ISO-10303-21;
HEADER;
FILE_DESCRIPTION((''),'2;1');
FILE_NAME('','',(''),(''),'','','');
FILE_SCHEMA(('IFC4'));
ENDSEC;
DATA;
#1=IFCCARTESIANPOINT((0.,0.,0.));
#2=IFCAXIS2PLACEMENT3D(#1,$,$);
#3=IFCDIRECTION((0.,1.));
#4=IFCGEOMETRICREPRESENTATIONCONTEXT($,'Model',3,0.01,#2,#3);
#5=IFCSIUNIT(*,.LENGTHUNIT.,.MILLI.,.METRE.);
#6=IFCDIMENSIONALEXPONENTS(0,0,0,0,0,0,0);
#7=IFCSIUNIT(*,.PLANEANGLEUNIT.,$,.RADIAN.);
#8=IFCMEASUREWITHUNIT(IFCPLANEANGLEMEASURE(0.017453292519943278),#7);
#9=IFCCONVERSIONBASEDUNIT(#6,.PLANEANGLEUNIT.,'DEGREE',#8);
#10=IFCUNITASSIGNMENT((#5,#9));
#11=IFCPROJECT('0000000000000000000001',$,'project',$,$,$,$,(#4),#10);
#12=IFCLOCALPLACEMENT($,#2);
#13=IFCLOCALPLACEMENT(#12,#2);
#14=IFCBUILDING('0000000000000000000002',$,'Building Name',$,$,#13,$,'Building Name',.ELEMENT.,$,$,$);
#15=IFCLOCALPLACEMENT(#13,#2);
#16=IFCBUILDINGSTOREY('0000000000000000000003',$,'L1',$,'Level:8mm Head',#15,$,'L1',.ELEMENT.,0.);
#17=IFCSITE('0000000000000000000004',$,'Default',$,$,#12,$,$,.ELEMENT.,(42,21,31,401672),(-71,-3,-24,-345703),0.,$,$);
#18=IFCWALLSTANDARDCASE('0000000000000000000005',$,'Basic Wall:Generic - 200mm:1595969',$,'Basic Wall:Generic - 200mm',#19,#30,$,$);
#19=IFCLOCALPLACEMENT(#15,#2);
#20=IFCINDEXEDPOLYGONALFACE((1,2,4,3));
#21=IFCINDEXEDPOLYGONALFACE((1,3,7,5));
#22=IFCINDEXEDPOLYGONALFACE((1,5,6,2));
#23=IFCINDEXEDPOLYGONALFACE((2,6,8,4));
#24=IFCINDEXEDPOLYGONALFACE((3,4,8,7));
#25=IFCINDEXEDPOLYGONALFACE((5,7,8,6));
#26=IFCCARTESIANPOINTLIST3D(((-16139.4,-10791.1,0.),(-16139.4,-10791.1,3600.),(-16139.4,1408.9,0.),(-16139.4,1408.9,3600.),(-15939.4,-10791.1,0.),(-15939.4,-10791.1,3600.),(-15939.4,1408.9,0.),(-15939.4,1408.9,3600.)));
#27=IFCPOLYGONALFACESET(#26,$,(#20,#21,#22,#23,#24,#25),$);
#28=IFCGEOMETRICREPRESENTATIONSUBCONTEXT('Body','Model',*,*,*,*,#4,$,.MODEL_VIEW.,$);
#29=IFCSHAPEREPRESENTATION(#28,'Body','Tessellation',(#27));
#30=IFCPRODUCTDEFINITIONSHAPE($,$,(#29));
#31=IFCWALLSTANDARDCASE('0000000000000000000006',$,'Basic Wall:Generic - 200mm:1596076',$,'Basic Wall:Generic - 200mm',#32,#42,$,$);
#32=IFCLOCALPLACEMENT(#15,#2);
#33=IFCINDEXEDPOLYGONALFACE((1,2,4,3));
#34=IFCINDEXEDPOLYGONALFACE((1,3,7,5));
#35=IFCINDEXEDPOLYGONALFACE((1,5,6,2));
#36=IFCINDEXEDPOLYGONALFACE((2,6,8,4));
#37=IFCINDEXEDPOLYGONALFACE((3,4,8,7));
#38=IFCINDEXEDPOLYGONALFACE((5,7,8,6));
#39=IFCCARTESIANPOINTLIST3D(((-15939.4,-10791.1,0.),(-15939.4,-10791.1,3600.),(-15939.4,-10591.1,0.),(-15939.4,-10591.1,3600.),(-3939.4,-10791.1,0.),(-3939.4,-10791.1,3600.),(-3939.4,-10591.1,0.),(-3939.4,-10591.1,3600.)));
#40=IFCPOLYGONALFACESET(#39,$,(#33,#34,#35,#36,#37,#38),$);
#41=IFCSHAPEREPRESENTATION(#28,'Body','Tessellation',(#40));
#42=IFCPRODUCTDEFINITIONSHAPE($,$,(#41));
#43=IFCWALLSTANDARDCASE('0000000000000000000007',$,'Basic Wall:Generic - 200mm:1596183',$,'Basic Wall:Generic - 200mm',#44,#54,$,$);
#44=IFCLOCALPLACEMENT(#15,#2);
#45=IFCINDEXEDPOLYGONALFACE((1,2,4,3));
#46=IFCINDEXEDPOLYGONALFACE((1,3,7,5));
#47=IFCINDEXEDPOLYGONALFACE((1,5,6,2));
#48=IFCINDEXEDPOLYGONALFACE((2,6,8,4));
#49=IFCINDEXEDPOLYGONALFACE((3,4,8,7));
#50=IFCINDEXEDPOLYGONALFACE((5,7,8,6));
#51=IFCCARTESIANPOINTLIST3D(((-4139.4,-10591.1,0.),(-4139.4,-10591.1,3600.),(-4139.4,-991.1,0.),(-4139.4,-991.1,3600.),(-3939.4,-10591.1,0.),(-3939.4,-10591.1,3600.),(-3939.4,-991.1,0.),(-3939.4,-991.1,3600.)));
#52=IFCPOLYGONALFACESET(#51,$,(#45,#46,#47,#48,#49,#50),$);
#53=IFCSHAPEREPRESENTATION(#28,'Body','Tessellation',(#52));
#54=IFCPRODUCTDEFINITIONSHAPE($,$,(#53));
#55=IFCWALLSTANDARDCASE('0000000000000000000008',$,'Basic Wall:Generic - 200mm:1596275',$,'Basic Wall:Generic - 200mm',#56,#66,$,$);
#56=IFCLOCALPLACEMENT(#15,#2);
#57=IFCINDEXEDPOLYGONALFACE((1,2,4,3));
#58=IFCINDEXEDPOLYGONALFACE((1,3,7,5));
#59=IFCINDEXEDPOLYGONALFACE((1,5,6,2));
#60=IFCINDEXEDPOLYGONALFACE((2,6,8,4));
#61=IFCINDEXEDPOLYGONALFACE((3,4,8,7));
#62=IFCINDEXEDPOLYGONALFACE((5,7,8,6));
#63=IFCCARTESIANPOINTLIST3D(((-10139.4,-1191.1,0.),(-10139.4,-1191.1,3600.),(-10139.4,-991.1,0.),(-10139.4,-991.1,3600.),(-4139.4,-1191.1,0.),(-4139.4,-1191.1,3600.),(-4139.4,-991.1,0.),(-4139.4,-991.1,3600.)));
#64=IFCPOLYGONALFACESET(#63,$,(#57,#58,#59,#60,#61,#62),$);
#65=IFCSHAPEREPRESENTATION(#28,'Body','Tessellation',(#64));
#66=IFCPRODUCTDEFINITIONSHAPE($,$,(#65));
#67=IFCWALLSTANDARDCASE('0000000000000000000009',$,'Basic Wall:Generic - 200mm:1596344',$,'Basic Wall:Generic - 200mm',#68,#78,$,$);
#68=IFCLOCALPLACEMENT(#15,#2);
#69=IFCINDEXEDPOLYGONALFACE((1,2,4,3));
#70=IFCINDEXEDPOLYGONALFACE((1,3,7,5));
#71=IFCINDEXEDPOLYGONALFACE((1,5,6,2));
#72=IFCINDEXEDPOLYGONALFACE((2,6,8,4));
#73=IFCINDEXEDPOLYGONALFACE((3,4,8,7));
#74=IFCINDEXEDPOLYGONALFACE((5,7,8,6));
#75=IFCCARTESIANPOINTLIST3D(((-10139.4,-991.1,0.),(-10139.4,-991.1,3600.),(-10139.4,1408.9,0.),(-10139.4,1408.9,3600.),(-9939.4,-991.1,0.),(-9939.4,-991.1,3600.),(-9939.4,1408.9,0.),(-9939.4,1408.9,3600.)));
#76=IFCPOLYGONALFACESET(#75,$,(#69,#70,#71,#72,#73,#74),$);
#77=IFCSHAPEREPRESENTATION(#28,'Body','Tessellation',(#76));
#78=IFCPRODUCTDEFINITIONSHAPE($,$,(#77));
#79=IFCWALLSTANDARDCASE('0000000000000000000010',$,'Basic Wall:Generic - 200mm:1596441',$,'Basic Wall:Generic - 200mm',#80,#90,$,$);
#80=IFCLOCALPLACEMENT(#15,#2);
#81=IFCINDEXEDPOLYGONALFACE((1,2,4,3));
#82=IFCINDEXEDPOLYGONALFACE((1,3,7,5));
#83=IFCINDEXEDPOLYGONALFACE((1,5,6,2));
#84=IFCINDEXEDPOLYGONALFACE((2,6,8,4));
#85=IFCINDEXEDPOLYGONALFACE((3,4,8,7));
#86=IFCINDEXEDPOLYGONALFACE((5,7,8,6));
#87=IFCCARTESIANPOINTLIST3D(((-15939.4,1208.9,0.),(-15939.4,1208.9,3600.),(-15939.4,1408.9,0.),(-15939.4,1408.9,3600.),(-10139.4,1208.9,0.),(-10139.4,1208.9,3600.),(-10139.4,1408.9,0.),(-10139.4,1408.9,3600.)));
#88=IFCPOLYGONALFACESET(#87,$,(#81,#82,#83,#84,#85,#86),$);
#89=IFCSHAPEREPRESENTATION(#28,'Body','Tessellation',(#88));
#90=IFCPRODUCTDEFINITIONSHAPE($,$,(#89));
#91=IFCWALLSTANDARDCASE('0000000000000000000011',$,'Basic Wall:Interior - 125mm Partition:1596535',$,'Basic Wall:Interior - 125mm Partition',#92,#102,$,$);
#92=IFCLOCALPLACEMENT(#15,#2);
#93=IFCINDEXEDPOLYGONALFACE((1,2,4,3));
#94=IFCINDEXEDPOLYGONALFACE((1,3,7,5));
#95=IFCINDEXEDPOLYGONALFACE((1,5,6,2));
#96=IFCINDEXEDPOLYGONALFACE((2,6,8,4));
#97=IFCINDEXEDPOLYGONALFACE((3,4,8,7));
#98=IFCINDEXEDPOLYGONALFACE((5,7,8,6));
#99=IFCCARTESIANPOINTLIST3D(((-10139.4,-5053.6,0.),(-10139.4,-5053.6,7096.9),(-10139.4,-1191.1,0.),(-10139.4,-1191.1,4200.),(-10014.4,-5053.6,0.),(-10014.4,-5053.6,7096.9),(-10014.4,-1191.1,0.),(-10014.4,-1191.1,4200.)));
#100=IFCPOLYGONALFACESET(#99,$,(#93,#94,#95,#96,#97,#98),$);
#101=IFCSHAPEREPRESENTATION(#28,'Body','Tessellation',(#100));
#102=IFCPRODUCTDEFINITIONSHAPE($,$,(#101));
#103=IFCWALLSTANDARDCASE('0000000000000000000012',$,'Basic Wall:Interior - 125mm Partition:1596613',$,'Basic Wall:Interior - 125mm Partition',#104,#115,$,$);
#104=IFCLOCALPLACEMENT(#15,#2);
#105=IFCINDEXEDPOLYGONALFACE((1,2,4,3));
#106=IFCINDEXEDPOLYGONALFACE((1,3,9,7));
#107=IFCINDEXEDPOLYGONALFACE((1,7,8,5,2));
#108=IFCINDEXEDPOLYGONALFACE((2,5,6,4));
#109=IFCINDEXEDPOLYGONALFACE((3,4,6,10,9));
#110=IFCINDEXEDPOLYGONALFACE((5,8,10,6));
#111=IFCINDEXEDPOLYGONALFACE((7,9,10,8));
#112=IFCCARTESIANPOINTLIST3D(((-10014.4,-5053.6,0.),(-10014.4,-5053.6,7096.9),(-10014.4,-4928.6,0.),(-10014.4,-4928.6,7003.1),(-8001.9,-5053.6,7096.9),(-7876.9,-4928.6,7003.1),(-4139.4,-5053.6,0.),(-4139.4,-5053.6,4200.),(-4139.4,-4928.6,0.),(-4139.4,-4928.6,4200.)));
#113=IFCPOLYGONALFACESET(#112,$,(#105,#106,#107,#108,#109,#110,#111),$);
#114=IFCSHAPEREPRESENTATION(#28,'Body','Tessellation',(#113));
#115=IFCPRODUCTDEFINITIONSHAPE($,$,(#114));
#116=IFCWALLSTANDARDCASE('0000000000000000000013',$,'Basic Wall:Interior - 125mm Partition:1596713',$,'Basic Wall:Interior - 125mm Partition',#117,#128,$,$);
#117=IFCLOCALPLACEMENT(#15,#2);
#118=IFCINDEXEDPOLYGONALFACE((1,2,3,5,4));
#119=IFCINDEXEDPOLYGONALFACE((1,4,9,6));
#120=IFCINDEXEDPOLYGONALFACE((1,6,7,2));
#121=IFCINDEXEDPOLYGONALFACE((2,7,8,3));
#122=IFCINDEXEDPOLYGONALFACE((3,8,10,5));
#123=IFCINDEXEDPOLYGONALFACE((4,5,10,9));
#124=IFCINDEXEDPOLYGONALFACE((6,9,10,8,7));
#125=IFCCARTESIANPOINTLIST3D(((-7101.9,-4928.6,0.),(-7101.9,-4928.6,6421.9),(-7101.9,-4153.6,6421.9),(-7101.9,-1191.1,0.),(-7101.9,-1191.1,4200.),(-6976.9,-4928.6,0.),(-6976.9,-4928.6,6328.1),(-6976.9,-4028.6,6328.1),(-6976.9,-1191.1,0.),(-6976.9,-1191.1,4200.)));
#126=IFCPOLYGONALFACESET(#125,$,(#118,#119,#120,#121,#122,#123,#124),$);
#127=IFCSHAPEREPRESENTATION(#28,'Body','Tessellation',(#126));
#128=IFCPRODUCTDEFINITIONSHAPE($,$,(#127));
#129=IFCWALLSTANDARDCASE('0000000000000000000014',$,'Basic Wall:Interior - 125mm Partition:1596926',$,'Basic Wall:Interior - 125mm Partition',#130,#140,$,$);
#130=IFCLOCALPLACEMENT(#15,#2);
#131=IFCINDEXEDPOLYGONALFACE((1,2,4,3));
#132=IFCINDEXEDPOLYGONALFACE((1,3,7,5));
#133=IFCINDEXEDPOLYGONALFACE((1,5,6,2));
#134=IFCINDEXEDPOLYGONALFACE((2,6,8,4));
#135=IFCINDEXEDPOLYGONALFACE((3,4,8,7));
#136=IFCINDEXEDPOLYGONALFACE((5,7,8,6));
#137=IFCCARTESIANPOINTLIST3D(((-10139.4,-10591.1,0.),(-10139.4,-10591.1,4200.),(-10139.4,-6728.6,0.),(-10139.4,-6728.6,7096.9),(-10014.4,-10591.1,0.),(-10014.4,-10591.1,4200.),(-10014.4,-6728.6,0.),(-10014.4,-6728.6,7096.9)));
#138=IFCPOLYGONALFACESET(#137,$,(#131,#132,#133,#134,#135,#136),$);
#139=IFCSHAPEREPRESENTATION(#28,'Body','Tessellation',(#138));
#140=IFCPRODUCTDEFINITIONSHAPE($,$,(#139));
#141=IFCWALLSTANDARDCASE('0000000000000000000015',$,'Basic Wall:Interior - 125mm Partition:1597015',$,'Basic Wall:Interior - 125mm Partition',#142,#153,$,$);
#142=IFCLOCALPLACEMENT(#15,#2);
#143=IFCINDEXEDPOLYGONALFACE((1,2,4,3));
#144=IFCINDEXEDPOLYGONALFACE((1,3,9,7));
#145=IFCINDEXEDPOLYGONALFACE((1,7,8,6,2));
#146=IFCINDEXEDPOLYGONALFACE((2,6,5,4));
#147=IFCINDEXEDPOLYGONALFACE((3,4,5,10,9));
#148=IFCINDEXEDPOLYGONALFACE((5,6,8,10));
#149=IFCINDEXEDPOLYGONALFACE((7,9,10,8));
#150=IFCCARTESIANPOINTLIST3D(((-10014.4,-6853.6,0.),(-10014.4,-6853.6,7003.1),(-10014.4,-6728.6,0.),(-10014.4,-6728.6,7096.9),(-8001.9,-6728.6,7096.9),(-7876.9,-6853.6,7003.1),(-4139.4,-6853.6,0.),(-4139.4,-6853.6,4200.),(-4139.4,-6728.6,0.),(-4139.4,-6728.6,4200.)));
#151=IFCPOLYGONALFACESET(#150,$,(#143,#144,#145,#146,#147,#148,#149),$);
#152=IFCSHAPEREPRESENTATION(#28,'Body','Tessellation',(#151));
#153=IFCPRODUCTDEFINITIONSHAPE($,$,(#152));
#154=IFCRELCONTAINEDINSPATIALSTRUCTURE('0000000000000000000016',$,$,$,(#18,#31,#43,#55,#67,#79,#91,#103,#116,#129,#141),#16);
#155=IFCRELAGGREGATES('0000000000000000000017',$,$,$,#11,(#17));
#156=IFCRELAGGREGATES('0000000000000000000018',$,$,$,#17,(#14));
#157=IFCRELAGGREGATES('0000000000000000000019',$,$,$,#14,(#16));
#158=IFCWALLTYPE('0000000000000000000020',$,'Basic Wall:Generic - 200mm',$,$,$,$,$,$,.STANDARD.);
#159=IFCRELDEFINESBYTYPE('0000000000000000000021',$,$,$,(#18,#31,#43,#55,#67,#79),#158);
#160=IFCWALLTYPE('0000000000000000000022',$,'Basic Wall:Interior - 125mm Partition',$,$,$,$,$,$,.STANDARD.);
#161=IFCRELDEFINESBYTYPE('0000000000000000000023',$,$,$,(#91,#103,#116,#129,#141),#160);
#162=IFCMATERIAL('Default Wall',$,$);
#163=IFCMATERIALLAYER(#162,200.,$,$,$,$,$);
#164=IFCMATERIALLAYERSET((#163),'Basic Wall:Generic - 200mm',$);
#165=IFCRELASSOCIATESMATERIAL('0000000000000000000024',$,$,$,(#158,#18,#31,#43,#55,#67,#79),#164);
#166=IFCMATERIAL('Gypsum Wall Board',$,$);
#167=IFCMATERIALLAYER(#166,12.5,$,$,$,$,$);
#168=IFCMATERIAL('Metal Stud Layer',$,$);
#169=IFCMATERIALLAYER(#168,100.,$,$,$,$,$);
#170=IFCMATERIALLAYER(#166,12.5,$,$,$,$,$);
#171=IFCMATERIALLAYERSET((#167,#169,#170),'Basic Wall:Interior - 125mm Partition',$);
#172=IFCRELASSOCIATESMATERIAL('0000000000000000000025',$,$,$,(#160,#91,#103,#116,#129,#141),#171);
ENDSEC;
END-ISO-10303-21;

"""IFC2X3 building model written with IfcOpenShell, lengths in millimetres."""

from ifc_helpers import new_model, entity, si_unit, converted_unit, direction, frame, frame_2d, origin, place, context, subcontext, project, spatial, polyline, rectangle, extrude, clip, bounded_halfspace, material, layer, layer_set, layer_usage, type_object, element, save


model = new_model("IFC2X3")

# Units and contexts
model_context = context("Model", 3, precision=0.01, world=origin(), true_north=direction((0.0, 1.0)))
body_context = subcontext(model_context, "Body", "Model", "MODEL_VIEW")
ifc_project = project(units=[si_unit("LENGTHUNIT", "METRE", prefix="MILLI"), converted_unit("PLANEANGLEUNIT", "DEGREE", entity("IfcPlaneAngleMeasure", 0.017453292519943278), si_unit("PLANEANGLEUNIT", "RADIAN"), dimensions=[0, 0, 0, 0, 0, 0, 0])], contexts=[model_context])

# Site, building, storey
site_placement = place(None, origin())
site = spatial("IfcSite", under=ifc_project, at=site_placement, Name="Default", CompositionType="ELEMENT", RefLatitude=(42, 21, 31, 401672), RefLongitude=(-71, -3, -24, -345703), RefElevation=0.0)
building_placement = place(site_placement, origin())
building = spatial("IfcBuilding", under=site, at=building_placement, Name="Building Name", LongName="Building Name", CompositionType="ELEMENT")
storey_placement = place(building_placement, origin())
storey = spatial("IfcBuildingStorey", under=building, at=storey_placement, Name="L1", ObjectType="Level:8mm Head", LongName="L1", CompositionType="ELEMENT", Elevation=0.0)

# Walls
ifc_material_1 = material(Name="Default Wall")
ifc_layer_1 = layer(ifc_material_1, 200.0)
ifc_layer_set_1 = layer_set([ifc_layer_1], Name="Basic Wall:Generic - 200mm")
ifc_layer_usage_1 = layer_usage(ifc_layer_set_1, "AXIS2", "NEGATIVE", 100.0)
wall_type_1 = type_object("IfcWallType", Name="Basic Wall:Generic - 200mm", PredefinedType="STANDARD", material=ifc_layer_set_1)
wall_1_placement = place(storey_placement, frame((-16039.4, 1408.9, 0.0), z_axis=(0.0, 0.0, 1.0), x_axis=(0.0, -1.0, 0.0)))
element("IfcWallStandardCase", 1, at=wall_1_placement, inside=storey, type_object=wall_type_1, material=ifc_layer_usage_1, Name="Basic Wall:Generic - 200mm:1595969", ObjectType="Basic Wall:Generic - 200mm", context=body_context, shape_type="SweptSolid", body=[
    extrude(rectangle(XDim=12200.0, YDim=200.0, at=frame_2d((6100.0, 0.0), x_axis=(-1.0, 0.0))), origin(), (0.0, 0.0, 1.0), 3600.0),
])
wall_2_placement = place(storey_placement, frame((-15939.4, -10691.1, 0.0)))
element("IfcWallStandardCase", 2, at=wall_2_placement, inside=storey, type_object=wall_type_1, material=ifc_layer_usage_1, Name="Basic Wall:Generic - 200mm:1596076", ObjectType="Basic Wall:Generic - 200mm", context=body_context, shape_type="SweptSolid", body=[
    extrude(rectangle(XDim=12000.0, YDim=200.0, at=frame_2d((6000.0, 0.0), x_axis=(-1.0, 0.0))), origin(), (0.0, 0.0, 1.0), 3600.0),
])
wall_3_placement = place(storey_placement, frame((-4039.4, -10591.1, 0.0), z_axis=(0.0, 0.0, 1.0), x_axis=(0.0, 1.0, 0.0)))
element("IfcWallStandardCase", 3, at=wall_3_placement, inside=storey, type_object=wall_type_1, material=ifc_layer_usage_1, Name="Basic Wall:Generic - 200mm:1596183", ObjectType="Basic Wall:Generic - 200mm", context=body_context, shape_type="SweptSolid", body=[
    extrude(rectangle(XDim=9600.0, YDim=200.0, at=frame_2d((4800.0, 0.0), x_axis=(-1.0, 0.0))), origin(), (0.0, 0.0, 1.0), 3600.0),
])
wall_4_placement = place(storey_placement, frame((-4139.4, -1091.1, 0.0), z_axis=(0.0, 0.0, 1.0), x_axis=(-1.0, 0.0, 0.0)))
element("IfcWallStandardCase", 4, at=wall_4_placement, inside=storey, type_object=wall_type_1, material=ifc_layer_usage_1, Name="Basic Wall:Generic - 200mm:1596275", ObjectType="Basic Wall:Generic - 200mm", context=body_context, shape_type="SweptSolid", body=[
    extrude(rectangle(XDim=6000.0, YDim=200.0, at=frame_2d((3000.0, 0.0), x_axis=(-1.0, 0.0))), origin(), (0.0, 0.0, 1.0), 3600.0),
])
wall_5_placement = place(storey_placement, frame((-10039.4, -991.1, 0.0), z_axis=(0.0, 0.0, 1.0), x_axis=(0.0, 1.0, 0.0)))
element("IfcWallStandardCase", 5, at=wall_5_placement, inside=storey, type_object=wall_type_1, material=ifc_layer_usage_1, Name="Basic Wall:Generic - 200mm:1596344", ObjectType="Basic Wall:Generic - 200mm", context=body_context, shape_type="SweptSolid", body=[
    extrude(rectangle(XDim=2400.0, YDim=200.0, at=frame_2d((1200.0, 0.0), x_axis=(-1.0, 0.0))), origin(), (0.0, 0.0, 1.0), 3600.0),
])
wall_6_placement = place(storey_placement, frame((-10139.4, 1308.9, 0.0), z_axis=(0.0, 0.0, 1.0), x_axis=(-1.0, 0.0, 0.0)))
element("IfcWallStandardCase", 6, at=wall_6_placement, inside=storey, type_object=wall_type_1, material=ifc_layer_usage_1, Name="Basic Wall:Generic - 200mm:1596441", ObjectType="Basic Wall:Generic - 200mm", context=body_context, shape_type="SweptSolid", body=[
    extrude(rectangle(XDim=5800.0, YDim=200.0, at=frame_2d((2900.0, 0.0), x_axis=(-1.0, 0.0))), origin(), (0.0, 0.0, 1.0), 3600.0),
])
ifc_material_2 = material(Name="Gypsum Wall Board")
ifc_layer_2 = layer(ifc_material_2, 12.5)
ifc_material_3 = material(Name="Metal Stud Layer")
ifc_layer_3 = layer(ifc_material_3, 100.0)
ifc_layer_4 = layer(ifc_material_2, 12.5)
ifc_layer_set_2 = layer_set([ifc_layer_2, ifc_layer_3, ifc_layer_4], Name="Basic Wall:Interior - 125mm Partition")
ifc_layer_usage_2 = layer_usage(ifc_layer_set_2, "AXIS2", "NEGATIVE", 62.5)
wall_type_2 = type_object("IfcWallType", Name="Basic Wall:Interior - 125mm Partition", PredefinedType="STANDARD", material=ifc_layer_set_2)
wall_7_placement = place(storey_placement, frame((-10076.9, -1191.1, 0.0), z_axis=(0.0, 0.0, 1.0), x_axis=(0.0, -1.0, 0.0)))
element("IfcWallStandardCase", 7, at=wall_7_placement, inside=storey, type_object=wall_type_2, material=ifc_layer_usage_2, Name="Basic Wall:Interior - 125mm Partition:1596535", ObjectType="Basic Wall:Interior - 125mm Partition", context=body_context, shape_type="Clipping", body=[
    clip(extrude(rectangle(XDim=3862.5, YDim=125.0, at=frame_2d((1931.3, 0.0), x_axis=(-1.0, 0.0))), origin(), (0.0, 0.0, 1.0), 7096.9), bounded_halfspace(frame((0.0, -62.5, 4200.0), z_axis=(-0.6, 0.0, 0.8), x_axis=(0.0, -1.0, 0.0)), False, frame((0.0, -62.5, 4200.0)), polyline([(0.0, 0.0), (3862.5, 0.0), (3862.5, 125.0), (3737.5, 125.0), (0.0, 125.0), (0.0, 0.0)]))),
])
wall_8_placement = place(storey_placement, frame((-10014.4, -4991.1, 0.0)))
element("IfcWallStandardCase", 8, at=wall_8_placement, inside=storey, type_object=wall_type_2, material=ifc_layer_usage_2, Name="Basic Wall:Interior - 125mm Partition:1596613", ObjectType="Basic Wall:Interior - 125mm Partition", context=body_context, shape_type="Clipping", body=[
    clip(clip(extrude(rectangle(XDim=5875.0, YDim=125.0, at=frame_2d((2937.5, 0.0), x_axis=(-1.0, 0.0))), origin(), (0.0, 0.0, 1.0), 7096.9), bounded_halfspace(frame((2012.5, -62.5, 7096.9), z_axis=(0.6, 0.0, 0.8), x_axis=(0.0, 1.0, 0.0)), False, frame((2012.5, -62.5, 7096.9)), polyline([(0.0, 0.0), (3862.5, 0.0), (3862.5, 125.0), (1025.0, 125.0), (900.0, 125.0), (125.0, 125.0), (0.0, 0.0)]))), bounded_halfspace(frame((0.0, -62.5, 7096.9), z_axis=(0.0, 0.6, 0.8), x_axis=(-1.0, 0.0, 0.0)), False, frame((0.0, -62.5, 7096.9)), polyline([(0.0, 0.0), (2012.5, 0.0), (2137.5, 125.0), (0.0, 125.0), (0.0, 0.0)]))),
])
wall_9_placement = place(storey_placement, frame((-7039.4, -4928.6, 0.0), z_axis=(0.0, 0.0, 1.0), x_axis=(0.0, 1.0, 0.0)))
element("IfcWallStandardCase", 9, at=wall_9_placement, inside=storey, type_object=wall_type_2, material=ifc_layer_usage_2, Name="Basic Wall:Interior - 125mm Partition:1596713", ObjectType="Basic Wall:Interior - 125mm Partition", context=body_context, shape_type="Clipping", body=[
    clip(clip(extrude(rectangle(XDim=3737.5, YDim=125.0, at=frame_2d((1868.8, 0.0), x_axis=(-1.0, 0.0))), origin(), (0.0, 0.0, 1.0), 6421.9), bounded_halfspace(frame((0.0, -62.5, 6328.1), z_axis=(0.0, -0.6, 0.8), x_axis=(1.0, 0.0, 0.0)), False, frame((0.0, -62.5, 6328.1)), polyline([(0.0, 0.0), (900.0, 0.0), (775.0, 125.0), (0.0, 125.0), (0.0, 0.0)]))), bounded_halfspace(frame((900.0, -62.5, 6328.1), z_axis=(0.6, 0.0, 0.8), x_axis=(0.0, 1.0, 0.0)), False, frame((900.0, -62.5, 6328.1)), polyline([(0.0, 0.0), (2837.5, 0.0), (2837.5, 125.0), (-125.0, 125.0), (0.0, 0.0)]))),
])
wall_10_placement = place(storey_placement, frame((-10076.9, -10591.1, 0.0), z_axis=(0.0, 0.0, 1.0), x_axis=(0.0, 1.0, 0.0)))
element("IfcWallStandardCase", 10, at=wall_10_placement, inside=storey, type_object=wall_type_2, material=ifc_layer_usage_2, Name="Basic Wall:Interior - 125mm Partition:1596926", ObjectType="Basic Wall:Interior - 125mm Partition", context=body_context, shape_type="Clipping", body=[
    clip(extrude(rectangle(XDim=3862.5, YDim=125.0, at=frame_2d((1931.3, 0.0), x_axis=(-1.0, 0.0))), origin(), (0.0, 0.0, 1.0), 7096.9), bounded_halfspace(frame((0.0, -62.5, 4200.0), z_axis=(-0.6, 0.0, 0.8), x_axis=(0.0, -1.0, 0.0)), False, frame((0.0, -62.5, 4200.0)), polyline([(0.0, 0.0), (3737.5, 0.0), (3862.5, 0.0), (3862.5, 125.0), (0.0, 125.0), (0.0, 0.0)]))),
])
wall_11_placement = place(storey_placement, frame((-10014.4, -6791.1, 0.0)))
element("IfcWallStandardCase", 11, at=wall_11_placement, inside=storey, type_object=wall_type_2, material=ifc_layer_usage_2, Name="Basic Wall:Interior - 125mm Partition:1597015", ObjectType="Basic Wall:Interior - 125mm Partition", context=body_context, shape_type="Clipping", body=[
    clip(clip(extrude(rectangle(XDim=5875.0, YDim=125.0, at=frame_2d((2937.5, 0.0), x_axis=(-1.0, 0.0))), origin(), (0.0, 0.0, 1.0), 7096.9), bounded_halfspace(frame((0.0, -62.5, 7003.1), z_axis=(0.0, -0.6, 0.8), x_axis=(1.0, 0.0, 0.0)), False, frame((0.0, -62.5, 7003.1)), polyline([(0.0, 0.0), (2137.5, 0.0), (2012.5, 125.0), (0.0, 125.0), (0.0, 0.0)]))), bounded_halfspace(frame((2137.5, -62.5, 7003.1), z_axis=(0.6, 0.0, 0.8), x_axis=(0.0, 1.0, 0.0)), False, frame((2137.5, -62.5, 7003.1)), polyline([(0.0, 0.0), (775.0, 0.0), (900.0, 0.0), (3737.5, 0.0), (3737.5, 125.0), (-125.0, 125.0), (0.0, 0.0)]))),
])

save(model, "model.ifc")
